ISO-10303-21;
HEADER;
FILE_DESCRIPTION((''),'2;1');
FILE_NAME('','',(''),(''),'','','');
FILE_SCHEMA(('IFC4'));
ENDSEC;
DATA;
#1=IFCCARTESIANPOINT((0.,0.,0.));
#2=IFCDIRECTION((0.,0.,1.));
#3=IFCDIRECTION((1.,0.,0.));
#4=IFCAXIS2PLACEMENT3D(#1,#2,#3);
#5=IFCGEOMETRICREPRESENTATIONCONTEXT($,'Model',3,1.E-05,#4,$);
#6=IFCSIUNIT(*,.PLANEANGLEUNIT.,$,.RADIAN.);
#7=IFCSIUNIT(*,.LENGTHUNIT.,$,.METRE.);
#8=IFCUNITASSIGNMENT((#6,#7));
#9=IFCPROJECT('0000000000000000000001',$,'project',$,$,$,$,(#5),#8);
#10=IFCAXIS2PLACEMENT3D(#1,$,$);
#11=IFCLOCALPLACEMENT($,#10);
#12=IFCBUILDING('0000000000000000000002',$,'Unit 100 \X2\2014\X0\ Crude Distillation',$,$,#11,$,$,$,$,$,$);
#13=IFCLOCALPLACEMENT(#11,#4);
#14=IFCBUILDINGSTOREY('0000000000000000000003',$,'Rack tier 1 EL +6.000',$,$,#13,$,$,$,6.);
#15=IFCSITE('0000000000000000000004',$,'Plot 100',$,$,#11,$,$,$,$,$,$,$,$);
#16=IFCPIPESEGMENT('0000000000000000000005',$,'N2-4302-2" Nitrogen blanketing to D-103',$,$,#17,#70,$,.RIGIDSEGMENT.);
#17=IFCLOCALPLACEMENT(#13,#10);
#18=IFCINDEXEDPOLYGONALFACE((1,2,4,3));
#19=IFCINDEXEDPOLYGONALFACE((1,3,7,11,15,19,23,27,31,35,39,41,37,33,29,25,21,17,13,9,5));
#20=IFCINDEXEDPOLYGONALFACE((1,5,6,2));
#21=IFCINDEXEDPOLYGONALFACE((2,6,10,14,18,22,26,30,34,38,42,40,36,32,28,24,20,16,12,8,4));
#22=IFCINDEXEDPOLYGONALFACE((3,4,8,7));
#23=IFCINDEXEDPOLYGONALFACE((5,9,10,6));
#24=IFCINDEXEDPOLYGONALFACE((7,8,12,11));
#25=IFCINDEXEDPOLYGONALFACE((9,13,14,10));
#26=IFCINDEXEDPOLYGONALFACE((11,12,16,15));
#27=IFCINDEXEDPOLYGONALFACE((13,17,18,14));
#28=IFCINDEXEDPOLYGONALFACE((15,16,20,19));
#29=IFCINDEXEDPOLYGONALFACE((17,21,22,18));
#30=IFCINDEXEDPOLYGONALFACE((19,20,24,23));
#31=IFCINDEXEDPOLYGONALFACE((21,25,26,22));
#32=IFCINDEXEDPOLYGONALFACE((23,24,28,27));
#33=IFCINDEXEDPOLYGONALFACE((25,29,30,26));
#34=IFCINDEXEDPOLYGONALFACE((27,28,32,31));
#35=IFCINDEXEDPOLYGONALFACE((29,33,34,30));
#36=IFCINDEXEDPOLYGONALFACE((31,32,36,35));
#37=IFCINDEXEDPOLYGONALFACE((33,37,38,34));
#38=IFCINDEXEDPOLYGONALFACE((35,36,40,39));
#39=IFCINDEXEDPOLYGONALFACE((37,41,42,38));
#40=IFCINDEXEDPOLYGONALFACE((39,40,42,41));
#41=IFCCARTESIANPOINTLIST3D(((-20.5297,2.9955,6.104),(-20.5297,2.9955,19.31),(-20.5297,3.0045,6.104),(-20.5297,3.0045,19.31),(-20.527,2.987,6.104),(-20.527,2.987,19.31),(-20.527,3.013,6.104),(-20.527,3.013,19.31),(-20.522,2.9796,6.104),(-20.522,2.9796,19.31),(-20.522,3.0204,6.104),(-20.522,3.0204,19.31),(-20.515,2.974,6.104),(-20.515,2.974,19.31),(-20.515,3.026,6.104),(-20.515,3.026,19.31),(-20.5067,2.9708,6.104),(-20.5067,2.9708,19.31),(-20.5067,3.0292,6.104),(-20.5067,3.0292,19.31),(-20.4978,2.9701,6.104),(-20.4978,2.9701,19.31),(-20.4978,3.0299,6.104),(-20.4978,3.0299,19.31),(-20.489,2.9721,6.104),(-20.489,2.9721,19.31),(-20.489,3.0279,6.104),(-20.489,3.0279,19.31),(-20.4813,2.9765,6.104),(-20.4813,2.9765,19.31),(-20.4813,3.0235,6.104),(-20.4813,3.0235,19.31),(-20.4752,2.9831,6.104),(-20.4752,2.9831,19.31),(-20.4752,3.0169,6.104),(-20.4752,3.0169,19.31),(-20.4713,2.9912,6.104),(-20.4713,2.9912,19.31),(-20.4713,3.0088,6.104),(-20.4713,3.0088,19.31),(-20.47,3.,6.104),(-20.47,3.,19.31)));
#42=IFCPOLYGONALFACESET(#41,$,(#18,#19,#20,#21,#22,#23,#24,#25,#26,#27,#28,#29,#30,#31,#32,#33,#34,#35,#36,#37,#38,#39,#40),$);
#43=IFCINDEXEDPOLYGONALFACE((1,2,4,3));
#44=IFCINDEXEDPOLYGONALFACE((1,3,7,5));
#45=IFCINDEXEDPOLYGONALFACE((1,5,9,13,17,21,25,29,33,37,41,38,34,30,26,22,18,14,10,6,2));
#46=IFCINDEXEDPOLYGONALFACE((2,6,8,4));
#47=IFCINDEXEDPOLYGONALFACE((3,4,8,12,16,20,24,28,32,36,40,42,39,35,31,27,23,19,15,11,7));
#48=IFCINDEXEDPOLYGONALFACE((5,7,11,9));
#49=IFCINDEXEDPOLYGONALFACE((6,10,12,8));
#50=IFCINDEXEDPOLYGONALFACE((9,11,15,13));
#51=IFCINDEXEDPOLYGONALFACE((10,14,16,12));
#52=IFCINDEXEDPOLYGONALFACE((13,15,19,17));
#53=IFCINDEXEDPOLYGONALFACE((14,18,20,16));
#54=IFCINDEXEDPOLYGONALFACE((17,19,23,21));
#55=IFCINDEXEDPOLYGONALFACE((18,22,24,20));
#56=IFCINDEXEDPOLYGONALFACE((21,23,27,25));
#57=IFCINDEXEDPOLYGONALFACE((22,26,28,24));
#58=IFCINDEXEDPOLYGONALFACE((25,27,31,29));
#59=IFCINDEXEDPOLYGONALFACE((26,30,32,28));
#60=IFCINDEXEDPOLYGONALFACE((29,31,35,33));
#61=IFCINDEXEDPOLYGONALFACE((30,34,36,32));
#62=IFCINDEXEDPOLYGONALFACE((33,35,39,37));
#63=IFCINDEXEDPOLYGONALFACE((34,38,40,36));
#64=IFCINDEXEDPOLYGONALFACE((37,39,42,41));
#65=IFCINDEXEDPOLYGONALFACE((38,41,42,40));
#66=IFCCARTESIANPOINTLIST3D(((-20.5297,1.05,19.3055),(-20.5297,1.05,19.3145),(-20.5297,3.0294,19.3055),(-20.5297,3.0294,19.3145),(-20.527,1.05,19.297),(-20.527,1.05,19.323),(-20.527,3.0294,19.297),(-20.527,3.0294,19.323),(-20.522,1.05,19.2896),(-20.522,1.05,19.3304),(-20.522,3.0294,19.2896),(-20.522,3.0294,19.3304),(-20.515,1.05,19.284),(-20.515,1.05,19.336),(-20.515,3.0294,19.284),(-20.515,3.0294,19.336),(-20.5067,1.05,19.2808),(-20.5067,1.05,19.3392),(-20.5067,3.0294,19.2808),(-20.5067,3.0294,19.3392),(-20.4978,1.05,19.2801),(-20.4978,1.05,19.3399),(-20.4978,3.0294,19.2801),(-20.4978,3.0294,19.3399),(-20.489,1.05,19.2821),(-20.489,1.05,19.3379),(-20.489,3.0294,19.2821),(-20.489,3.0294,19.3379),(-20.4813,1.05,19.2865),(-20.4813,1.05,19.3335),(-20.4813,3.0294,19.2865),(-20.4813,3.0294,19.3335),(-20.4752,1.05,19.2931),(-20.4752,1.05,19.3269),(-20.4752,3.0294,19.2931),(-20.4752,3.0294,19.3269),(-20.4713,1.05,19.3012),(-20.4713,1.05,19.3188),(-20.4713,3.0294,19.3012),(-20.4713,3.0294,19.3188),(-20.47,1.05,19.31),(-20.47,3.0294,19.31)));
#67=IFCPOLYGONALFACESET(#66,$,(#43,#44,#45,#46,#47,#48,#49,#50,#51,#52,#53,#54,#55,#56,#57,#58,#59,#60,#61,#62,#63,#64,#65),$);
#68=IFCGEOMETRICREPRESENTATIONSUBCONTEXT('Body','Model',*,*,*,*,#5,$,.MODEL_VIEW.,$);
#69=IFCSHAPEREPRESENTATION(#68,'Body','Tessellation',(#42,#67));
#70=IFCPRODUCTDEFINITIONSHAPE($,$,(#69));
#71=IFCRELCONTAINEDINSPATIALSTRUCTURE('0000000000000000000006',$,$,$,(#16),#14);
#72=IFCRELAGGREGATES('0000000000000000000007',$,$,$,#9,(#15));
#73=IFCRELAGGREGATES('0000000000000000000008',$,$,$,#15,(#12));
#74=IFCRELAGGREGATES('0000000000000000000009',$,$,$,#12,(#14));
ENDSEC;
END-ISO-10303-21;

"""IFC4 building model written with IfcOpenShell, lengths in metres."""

from ifc_helpers import new_model, si_unit, frame, origin, origin_with_axes, origin_2d, place, context, subcontext, project, spatial, circle, extrude, element, save


model = new_model("IFC4")

# Units and contexts
model_context = context("Model", 3, precision=1e-05, world=origin_with_axes())
body_context = subcontext(model_context, "Body", "Model", "MODEL_VIEW")
ifc_project = project(units=[si_unit("PLANEANGLEUNIT", "RADIAN"), si_unit("LENGTHUNIT", "METRE")], contexts=[model_context])

# Site, building, storey
placement = place(None, origin())
site = spatial("IfcSite", under=ifc_project, at=placement, Name="Plot 100")
building = spatial("IfcBuilding", under=site, at=placement, Name="Unit 100 — Crude Distillation")
storey_placement = place(placement, origin_with_axes())
storey = spatial("IfcBuildingStorey", under=building, at=storey_placement, Name="Rack tier 1 EL +6.000", Elevation=6.0)

# Pipe segment
pipe_segment_placement = place(storey_placement, origin_with_axes())
element("IfcPipeSegment", 1, at=pipe_segment_placement, inside=storey, Name="N2-4302-2\" Nitrogen blanketing to D-103", PredefinedType="RIGIDSEGMENT", context=body_context, shape_type="SweptSolid", body=[
    extrude(circle(Radius=0.03, at=origin_2d()), frame((-20.5, 3.0, 6.104), z_axis=(0.0, 0.0, 1.0), x_axis=(1.0, 0.0, 0.0)), (0.0, 0.0, 1.0), 13.206),
    extrude(circle(Radius=0.03, at=origin_2d()), frame((-20.5, 3.0294, 19.31), z_axis=(0.0, -1.0, 0.0), x_axis=(1.0, 0.0, 0.0)), (0.0, 0.0, 1.0), 1.9794),
])

save(model, "model.ifc")
